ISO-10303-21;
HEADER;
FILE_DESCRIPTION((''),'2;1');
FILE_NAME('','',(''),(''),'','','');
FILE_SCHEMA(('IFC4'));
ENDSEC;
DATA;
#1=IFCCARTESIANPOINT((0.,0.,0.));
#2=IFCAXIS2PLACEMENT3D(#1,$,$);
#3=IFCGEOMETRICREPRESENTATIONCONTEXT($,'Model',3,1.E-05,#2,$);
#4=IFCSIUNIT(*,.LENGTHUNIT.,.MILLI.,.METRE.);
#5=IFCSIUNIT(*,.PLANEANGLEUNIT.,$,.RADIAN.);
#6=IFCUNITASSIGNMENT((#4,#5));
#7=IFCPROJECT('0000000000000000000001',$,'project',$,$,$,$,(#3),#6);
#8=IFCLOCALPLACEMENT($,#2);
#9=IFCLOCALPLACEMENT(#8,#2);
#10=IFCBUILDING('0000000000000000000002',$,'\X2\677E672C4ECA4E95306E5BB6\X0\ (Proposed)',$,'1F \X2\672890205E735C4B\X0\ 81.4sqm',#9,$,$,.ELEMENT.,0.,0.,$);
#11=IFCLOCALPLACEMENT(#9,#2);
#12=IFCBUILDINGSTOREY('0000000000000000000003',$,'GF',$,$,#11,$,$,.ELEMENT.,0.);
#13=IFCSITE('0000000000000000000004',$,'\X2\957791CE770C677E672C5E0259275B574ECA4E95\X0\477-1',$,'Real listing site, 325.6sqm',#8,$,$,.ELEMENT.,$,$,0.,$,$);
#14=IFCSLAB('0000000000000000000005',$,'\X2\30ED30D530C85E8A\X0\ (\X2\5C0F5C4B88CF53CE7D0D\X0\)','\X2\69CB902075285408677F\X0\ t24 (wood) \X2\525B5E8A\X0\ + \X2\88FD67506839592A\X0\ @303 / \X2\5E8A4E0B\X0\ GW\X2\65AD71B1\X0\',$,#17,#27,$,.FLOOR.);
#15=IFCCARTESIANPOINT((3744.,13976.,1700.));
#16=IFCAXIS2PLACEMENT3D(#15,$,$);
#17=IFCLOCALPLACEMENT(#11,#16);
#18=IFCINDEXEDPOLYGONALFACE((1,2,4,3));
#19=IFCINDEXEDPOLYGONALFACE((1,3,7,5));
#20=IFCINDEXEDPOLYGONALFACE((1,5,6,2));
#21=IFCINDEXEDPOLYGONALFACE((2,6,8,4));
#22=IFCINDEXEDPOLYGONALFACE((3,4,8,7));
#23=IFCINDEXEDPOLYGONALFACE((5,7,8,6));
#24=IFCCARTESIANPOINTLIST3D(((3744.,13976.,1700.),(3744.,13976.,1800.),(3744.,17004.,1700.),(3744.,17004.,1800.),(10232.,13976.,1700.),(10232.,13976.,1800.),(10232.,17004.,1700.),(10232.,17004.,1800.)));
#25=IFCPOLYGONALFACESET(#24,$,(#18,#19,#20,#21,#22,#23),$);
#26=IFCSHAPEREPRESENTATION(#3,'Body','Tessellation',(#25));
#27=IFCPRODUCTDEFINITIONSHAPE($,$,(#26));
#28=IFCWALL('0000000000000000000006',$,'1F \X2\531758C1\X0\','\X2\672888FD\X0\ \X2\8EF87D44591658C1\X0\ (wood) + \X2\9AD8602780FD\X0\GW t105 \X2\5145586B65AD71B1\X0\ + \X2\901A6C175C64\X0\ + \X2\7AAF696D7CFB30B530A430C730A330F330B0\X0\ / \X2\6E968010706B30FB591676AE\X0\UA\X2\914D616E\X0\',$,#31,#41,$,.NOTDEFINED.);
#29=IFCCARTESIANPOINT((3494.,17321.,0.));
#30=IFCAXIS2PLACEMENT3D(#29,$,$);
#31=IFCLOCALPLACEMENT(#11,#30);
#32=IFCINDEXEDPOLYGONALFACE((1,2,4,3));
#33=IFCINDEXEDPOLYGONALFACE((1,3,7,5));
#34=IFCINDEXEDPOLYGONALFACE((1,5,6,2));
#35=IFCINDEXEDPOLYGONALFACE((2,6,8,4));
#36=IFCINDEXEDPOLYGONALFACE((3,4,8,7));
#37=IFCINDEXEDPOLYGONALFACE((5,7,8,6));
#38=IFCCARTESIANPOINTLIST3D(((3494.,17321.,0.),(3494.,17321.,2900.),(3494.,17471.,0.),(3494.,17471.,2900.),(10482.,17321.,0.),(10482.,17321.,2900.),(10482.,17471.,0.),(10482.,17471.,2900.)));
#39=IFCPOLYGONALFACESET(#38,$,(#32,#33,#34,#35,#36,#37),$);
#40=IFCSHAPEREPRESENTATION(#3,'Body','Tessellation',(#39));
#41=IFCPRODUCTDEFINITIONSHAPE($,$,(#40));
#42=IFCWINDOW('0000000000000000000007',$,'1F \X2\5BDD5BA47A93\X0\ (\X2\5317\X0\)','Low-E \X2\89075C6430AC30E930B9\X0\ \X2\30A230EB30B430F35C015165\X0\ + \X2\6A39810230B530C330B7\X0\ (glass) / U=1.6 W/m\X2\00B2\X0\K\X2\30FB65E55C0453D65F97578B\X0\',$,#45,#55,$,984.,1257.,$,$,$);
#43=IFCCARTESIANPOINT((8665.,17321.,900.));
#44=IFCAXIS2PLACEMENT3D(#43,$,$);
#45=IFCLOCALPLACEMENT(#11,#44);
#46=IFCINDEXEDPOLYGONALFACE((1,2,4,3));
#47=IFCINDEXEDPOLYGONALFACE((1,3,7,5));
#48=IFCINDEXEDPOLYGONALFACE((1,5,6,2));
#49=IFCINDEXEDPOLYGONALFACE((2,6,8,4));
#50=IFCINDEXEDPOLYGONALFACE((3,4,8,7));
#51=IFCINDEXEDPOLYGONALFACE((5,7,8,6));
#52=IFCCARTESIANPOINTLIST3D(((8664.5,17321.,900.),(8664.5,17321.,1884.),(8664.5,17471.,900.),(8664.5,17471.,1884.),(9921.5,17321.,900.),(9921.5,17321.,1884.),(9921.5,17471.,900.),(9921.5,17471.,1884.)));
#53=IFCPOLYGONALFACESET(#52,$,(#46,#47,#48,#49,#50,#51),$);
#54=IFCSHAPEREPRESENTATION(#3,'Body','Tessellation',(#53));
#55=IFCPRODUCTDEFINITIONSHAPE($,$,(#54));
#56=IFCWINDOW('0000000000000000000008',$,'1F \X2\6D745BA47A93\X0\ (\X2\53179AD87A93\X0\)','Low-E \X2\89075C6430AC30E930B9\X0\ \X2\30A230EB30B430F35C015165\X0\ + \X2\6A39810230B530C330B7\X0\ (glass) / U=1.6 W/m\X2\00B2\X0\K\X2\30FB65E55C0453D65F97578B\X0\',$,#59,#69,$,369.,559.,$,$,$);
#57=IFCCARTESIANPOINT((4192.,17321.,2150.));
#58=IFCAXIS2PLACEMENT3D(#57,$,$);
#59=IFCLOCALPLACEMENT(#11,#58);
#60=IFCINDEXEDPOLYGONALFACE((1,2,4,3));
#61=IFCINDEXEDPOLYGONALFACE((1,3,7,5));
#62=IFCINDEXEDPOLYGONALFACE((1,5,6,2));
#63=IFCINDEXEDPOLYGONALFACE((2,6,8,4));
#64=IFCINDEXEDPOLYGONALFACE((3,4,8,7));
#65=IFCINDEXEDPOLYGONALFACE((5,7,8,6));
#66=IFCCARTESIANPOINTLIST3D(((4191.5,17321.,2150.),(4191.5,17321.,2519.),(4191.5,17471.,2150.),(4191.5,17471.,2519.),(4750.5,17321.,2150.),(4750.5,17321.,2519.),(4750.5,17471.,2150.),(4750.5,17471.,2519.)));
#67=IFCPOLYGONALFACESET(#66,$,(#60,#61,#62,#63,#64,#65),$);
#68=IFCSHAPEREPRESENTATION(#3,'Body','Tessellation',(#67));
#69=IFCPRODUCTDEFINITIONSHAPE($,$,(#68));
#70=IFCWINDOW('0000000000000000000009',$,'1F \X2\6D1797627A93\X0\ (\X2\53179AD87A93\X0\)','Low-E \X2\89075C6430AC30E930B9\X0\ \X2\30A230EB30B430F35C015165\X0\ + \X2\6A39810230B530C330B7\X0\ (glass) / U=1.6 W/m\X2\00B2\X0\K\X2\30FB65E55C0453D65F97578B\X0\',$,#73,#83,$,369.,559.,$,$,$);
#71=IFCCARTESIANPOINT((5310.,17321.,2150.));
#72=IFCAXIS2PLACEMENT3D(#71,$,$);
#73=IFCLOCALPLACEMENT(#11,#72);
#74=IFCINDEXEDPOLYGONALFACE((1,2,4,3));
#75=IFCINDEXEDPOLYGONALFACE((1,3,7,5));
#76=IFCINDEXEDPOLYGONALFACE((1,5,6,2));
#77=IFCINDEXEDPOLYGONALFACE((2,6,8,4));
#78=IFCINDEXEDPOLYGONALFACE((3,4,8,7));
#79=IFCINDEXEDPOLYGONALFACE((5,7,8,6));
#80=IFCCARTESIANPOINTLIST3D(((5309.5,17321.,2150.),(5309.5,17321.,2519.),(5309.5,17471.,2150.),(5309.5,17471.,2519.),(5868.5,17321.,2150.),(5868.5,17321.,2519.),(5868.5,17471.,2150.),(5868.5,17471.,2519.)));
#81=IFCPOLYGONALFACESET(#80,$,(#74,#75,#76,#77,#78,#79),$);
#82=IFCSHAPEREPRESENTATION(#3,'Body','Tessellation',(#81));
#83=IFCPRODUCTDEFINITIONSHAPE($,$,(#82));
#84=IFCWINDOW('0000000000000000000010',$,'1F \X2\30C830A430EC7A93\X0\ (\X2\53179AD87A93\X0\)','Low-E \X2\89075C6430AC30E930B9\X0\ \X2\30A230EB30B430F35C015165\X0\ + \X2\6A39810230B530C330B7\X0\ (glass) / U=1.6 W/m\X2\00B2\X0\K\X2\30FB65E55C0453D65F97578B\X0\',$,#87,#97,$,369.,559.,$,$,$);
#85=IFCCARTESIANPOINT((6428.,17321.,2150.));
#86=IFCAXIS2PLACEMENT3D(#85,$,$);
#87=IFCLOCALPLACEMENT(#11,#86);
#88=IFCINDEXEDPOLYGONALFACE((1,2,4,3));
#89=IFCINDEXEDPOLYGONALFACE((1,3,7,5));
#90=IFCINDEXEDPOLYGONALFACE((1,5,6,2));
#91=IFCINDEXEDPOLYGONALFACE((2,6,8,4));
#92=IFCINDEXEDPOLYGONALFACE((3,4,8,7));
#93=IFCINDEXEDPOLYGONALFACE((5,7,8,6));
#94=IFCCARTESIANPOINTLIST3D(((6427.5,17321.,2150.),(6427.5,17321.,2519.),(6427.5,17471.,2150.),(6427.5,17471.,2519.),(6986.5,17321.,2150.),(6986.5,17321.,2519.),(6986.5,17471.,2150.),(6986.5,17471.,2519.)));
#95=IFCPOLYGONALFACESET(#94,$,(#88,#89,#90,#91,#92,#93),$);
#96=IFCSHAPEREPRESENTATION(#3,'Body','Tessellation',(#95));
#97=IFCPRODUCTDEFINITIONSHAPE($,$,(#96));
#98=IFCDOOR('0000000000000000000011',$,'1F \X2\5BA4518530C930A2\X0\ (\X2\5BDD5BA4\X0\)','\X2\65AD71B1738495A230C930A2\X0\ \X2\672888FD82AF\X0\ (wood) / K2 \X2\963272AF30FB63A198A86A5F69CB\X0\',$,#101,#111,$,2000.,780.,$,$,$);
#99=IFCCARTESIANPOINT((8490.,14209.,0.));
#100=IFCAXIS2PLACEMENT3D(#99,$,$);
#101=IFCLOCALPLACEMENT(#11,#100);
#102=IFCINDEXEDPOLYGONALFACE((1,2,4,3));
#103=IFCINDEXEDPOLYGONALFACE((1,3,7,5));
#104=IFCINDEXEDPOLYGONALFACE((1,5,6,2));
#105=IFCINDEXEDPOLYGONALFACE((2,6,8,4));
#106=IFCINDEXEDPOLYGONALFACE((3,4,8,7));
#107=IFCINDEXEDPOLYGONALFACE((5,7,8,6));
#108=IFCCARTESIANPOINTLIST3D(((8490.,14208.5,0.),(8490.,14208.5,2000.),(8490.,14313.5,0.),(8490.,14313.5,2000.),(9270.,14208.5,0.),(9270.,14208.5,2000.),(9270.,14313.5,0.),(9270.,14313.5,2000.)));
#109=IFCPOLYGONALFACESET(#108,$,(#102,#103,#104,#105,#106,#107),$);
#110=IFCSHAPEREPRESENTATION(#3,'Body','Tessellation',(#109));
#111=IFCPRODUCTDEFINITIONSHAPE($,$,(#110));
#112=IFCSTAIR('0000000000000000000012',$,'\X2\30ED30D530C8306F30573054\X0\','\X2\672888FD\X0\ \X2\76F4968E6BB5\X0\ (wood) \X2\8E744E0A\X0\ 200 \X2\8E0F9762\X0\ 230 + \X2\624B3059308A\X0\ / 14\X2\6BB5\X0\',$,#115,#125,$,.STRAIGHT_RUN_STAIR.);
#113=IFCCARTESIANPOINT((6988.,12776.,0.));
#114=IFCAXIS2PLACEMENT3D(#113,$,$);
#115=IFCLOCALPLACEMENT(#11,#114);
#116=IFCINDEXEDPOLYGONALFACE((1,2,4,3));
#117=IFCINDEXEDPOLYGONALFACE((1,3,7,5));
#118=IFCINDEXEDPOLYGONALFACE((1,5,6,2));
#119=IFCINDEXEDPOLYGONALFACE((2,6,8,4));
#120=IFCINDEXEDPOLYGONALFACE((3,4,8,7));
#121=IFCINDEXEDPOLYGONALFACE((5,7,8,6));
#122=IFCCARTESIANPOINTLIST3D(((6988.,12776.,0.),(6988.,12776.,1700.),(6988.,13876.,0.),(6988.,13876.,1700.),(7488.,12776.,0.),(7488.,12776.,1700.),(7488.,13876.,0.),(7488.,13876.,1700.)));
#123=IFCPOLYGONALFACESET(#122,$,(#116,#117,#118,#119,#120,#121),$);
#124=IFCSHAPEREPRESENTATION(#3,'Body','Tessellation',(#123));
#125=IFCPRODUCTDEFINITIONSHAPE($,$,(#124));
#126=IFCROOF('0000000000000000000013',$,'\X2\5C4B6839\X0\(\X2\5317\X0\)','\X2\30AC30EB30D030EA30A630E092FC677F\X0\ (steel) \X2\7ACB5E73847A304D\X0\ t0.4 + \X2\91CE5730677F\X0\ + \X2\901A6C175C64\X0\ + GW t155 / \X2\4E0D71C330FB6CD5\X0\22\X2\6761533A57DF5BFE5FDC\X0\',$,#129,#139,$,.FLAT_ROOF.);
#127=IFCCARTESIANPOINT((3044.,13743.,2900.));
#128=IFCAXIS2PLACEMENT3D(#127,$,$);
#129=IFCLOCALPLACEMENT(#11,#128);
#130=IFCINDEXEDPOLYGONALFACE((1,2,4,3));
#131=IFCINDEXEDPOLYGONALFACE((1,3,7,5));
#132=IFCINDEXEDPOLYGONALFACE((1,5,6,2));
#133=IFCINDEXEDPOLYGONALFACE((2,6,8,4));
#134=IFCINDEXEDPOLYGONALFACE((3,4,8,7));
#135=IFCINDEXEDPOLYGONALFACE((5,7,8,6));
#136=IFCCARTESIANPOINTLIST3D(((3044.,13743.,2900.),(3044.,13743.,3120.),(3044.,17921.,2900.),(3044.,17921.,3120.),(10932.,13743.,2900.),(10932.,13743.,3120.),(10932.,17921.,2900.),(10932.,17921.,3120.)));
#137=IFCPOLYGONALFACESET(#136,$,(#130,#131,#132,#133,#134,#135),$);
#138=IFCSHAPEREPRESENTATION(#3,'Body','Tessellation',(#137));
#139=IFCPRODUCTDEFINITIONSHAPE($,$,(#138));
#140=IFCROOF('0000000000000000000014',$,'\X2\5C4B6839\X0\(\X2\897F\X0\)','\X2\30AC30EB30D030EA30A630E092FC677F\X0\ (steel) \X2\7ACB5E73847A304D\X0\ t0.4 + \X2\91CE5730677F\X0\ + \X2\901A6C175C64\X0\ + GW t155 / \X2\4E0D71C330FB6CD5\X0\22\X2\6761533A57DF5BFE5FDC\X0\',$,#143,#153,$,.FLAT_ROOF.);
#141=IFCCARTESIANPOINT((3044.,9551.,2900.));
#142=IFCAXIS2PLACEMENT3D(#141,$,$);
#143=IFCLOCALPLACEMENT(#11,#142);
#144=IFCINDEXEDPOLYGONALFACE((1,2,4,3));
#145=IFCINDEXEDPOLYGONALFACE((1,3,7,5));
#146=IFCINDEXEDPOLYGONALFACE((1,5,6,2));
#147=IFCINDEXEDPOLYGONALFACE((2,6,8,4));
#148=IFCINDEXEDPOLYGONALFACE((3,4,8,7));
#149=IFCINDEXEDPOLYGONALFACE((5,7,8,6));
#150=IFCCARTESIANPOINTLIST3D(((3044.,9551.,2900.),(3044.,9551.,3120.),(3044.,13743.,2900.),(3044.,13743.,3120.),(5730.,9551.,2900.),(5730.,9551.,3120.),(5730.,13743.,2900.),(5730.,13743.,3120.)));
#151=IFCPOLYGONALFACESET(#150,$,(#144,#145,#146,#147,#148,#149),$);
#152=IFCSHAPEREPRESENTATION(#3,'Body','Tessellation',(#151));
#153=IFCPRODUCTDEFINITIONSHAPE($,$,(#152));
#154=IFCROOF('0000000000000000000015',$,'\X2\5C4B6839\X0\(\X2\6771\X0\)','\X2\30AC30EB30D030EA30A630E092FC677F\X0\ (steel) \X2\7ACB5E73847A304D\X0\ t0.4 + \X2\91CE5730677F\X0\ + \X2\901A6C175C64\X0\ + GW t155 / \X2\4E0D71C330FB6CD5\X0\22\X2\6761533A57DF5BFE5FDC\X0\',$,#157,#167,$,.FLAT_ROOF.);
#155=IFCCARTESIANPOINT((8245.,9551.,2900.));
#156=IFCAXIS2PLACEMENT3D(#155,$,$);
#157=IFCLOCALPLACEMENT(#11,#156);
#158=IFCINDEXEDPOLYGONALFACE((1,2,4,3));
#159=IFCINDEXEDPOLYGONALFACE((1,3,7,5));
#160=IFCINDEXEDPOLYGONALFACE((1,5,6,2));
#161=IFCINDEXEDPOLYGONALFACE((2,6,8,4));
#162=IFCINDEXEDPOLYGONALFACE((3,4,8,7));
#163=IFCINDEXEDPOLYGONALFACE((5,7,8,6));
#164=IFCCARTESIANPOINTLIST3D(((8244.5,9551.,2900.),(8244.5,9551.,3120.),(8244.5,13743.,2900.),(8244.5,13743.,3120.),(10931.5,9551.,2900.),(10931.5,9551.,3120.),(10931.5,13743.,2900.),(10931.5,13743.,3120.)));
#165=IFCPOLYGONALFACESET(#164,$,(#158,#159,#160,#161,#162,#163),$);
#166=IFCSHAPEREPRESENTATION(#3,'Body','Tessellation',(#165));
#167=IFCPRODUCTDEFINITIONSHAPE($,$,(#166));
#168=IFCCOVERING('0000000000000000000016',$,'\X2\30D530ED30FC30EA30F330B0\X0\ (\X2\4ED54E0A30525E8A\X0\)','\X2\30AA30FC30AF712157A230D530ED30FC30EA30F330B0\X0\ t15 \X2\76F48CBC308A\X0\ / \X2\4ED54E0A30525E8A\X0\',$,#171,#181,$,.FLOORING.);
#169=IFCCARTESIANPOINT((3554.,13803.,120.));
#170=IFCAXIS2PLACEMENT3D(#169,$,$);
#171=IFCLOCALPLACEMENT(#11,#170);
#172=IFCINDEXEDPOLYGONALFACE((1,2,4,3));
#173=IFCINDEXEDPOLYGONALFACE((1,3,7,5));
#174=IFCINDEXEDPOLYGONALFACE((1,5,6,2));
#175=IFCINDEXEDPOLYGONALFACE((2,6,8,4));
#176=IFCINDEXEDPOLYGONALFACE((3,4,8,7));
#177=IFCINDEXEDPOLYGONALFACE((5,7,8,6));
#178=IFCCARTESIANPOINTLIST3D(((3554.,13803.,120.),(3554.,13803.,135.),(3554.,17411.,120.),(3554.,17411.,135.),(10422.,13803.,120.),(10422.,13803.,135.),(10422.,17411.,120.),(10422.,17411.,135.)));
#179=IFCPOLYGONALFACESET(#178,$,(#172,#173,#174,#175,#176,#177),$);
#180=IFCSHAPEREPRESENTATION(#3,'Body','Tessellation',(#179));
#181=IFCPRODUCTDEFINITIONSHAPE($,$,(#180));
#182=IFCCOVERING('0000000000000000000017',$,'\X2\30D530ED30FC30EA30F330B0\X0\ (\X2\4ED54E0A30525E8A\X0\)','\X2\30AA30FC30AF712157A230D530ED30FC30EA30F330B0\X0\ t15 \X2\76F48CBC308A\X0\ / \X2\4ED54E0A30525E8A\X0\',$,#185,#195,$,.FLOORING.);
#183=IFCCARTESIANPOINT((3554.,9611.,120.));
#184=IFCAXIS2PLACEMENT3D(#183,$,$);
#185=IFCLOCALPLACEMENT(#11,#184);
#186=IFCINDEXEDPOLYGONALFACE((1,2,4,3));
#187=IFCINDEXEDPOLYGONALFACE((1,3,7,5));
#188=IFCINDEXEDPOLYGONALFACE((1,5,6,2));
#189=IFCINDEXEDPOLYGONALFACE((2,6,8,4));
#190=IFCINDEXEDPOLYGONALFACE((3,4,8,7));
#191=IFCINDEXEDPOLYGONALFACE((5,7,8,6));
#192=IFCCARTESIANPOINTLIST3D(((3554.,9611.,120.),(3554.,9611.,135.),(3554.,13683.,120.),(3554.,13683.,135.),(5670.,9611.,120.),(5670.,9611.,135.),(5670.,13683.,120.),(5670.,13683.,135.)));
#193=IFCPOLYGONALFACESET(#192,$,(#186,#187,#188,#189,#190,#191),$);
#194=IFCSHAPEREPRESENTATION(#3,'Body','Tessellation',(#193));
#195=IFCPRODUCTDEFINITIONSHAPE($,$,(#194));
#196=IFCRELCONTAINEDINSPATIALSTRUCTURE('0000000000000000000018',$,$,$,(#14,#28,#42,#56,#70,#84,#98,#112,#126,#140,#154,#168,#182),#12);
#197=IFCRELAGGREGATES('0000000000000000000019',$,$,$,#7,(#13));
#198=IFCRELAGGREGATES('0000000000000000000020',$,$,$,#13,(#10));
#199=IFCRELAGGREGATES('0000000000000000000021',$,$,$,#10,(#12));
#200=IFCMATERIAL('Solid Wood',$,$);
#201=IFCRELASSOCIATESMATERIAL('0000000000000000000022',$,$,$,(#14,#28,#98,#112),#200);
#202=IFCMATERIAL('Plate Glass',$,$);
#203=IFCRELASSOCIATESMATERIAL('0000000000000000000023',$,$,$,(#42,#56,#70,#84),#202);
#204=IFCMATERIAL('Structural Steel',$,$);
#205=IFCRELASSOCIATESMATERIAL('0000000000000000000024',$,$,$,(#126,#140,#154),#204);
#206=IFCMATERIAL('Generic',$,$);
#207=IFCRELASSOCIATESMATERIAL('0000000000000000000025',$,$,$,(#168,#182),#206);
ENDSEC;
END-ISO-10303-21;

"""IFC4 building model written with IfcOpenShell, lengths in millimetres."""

from ifc_helpers import new_model, si_unit, frame, frame_2d, origin, place, context, project, spatial, rectangle, extrude, material, element, fill, save


model = new_model("IFC4")

# Units and contexts
model_context = context("Model", 3, precision=1e-05, world=origin())
ifc_project = project(units=[si_unit("LENGTHUNIT", "METRE", prefix="MILLI"), si_unit("PLANEANGLEUNIT", "RADIAN")], contexts=[model_context])

# Site, building, storey
site_placement = place(None, origin())
site = spatial("IfcSite", under=ifc_project, at=site_placement, Name="長野県松本市大字今井477-1", ObjectType="Real listing site, 325.6sqm", CompositionType="ELEMENT", RefElevation=0.0)
building_placement = place(site_placement, origin())
building = spatial("IfcBuilding", under=site, at=building_placement, Name="松本今井の家 (Proposed)", ObjectType="1F 木造平屋 81.4sqm", CompositionType="ELEMENT", ElevationOfRefHeight=0.0, ElevationOfTerrain=0.0)
storey_placement = place(building_placement, origin())
storey = spatial("IfcBuildingStorey", under=building, at=storey_placement, Name="GF", CompositionType="ELEMENT", Elevation=0.0)

# Slab
ifc_material_1 = material(Name="Solid Wood")
slab_1_placement = place(storey_placement, frame((3744.0, 13976.0, 1700.0)))
element("IfcSlab", 1, at=slab_1_placement, inside=storey, material=ifc_material_1, Name="ロフト床 (小屋裏収納)", Description="構造用合板 t24 (wood) 剛床 + 製材根太 @303 / 床下 GW断熱", PredefinedType="FLOOR", context=model_context, shape_type="SweptSolid", body=[
    extrude(rectangle(XDim=6488.0, YDim=3028.0, at=frame_2d((3244.0, 1514.0))), frame((3744.0, 13976.0, 1700.0)), (0.0, 0.0, 1.0), 100.0),
])

# Wall, openings, windows
wall_1_placement = place(storey_placement, frame((3494.0, 17321.0, 0.0)))
wall_1 = element("IfcWall", 2, at=wall_1_placement, inside=storey, material=ifc_material_1, Name="1F 北壁", Description="木製 軸組外壁 (wood) + 高性能GW t105 充填断熱 + 通気層 + 窯業系サイディング / 準耐火・外皮UA配慮", PredefinedType="NOTDEFINED", context=model_context, shape_type="SweptSolid", body=[
    extrude(rectangle(XDim=6988.0, YDim=150.0, at=frame_2d((3494.0, 75.0))), frame((3494.0, 17321.0, 0.0)), (0.0, 0.0, 1.0), 2900.0),
])
opening_1_placement = place(storey_placement, frame((8665.0, 17321.0, 900.0)))
opening_1 = element("IfcOpeningElement", 3, at=opening_1_placement, cuts=wall_1, PredefinedType="NOTDEFINED", context=model_context, shape_type="SweptSolid", body=[
    extrude(rectangle(XDim=1257.0, YDim=150.0, at=frame_2d((628.0, 75.0))), frame((8665.0, 17321.0, 900.0)), (0.0, 0.0, 1.0), 984.0),
])
opening_2_placement = place(storey_placement, frame((4192.0, 17321.0, 2150.0)))
opening_2 = element("IfcOpeningElement", 4, at=opening_2_placement, cuts=wall_1, PredefinedType="NOTDEFINED", context=model_context, shape_type="SweptSolid", body=[
    extrude(rectangle(XDim=559.0, YDim=150.0, at=frame_2d((279.0, 75.0))), frame((4192.0, 17321.0, 2150.0)), (0.0, 0.0, 1.0), 369.0),
])
opening_3_placement = place(storey_placement, frame((5310.0, 17321.0, 2150.0)))
opening_3 = element("IfcOpeningElement", 5, at=opening_3_placement, cuts=wall_1, PredefinedType="NOTDEFINED", context=model_context, shape_type="SweptSolid", body=[
    extrude(rectangle(XDim=559.0, YDim=150.0, at=frame_2d((279.0, 75.0))), frame((5310.0, 17321.0, 2150.0)), (0.0, 0.0, 1.0), 369.0),
])
opening_4_placement = place(storey_placement, frame((6428.0, 17321.0, 2150.0)))
opening_4 = element("IfcOpeningElement", 6, at=opening_4_placement, cuts=wall_1, PredefinedType="NOTDEFINED", context=model_context, shape_type="SweptSolid", body=[
    extrude(rectangle(XDim=559.0, YDim=150.0, at=frame_2d((279.0, 75.0))), frame((6428.0, 17321.0, 2150.0)), (0.0, 0.0, 1.0), 369.0),
])
ifc_material_2 = material(Name="Plate Glass")
window_1_placement = place(storey_placement, frame((8665.0, 17321.0, 900.0)))
window_1 = element("IfcWindow", 7, at=window_1_placement, inside=storey, material=ifc_material_2, Name="1F 寝室窓 (北)", Description="Low-E 複層ガラス アルゴン封入 + 樹脂サッシ (glass) / U=1.6 W/m²K・日射取得型", OverallHeight=984.0, OverallWidth=1257.0, context=model_context, shape_type="SweptSolid", body=[
    extrude(rectangle(XDim=1257.0, YDim=150.0, at=frame_2d((628.0, 75.0))), frame((8665.0, 17321.0, 900.0)), (0.0, 0.0, 1.0), 984.0),
])
fill(opening_1, window_1)
window_2_placement = place(storey_placement, frame((4192.0, 17321.0, 2150.0)))
window_2 = element("IfcWindow", 8, at=window_2_placement, inside=storey, material=ifc_material_2, Name="1F 浴室窓 (北高窓)", Description="Low-E 複層ガラス アルゴン封入 + 樹脂サッシ (glass) / U=1.6 W/m²K・日射取得型", OverallHeight=369.0, OverallWidth=559.0, context=model_context, shape_type="SweptSolid", body=[
    extrude(rectangle(XDim=559.0, YDim=150.0, at=frame_2d((279.0, 75.0))), frame((4192.0, 17321.0, 2150.0)), (0.0, 0.0, 1.0), 369.0),
])
fill(opening_2, window_2)
window_3_placement = place(storey_placement, frame((5310.0, 17321.0, 2150.0)))
window_3 = element("IfcWindow", 9, at=window_3_placement, inside=storey, material=ifc_material_2, Name="1F 洗面窓 (北高窓)", Description="Low-E 複層ガラス アルゴン封入 + 樹脂サッシ (glass) / U=1.6 W/m²K・日射取得型", OverallHeight=369.0, OverallWidth=559.0, context=model_context, shape_type="SweptSolid", body=[
    extrude(rectangle(XDim=559.0, YDim=150.0, at=frame_2d((279.0, 75.0))), frame((5310.0, 17321.0, 2150.0)), (0.0, 0.0, 1.0), 369.0),
])
fill(opening_3, window_3)
window_4_placement = place(storey_placement, frame((6428.0, 17321.0, 2150.0)))
window_4 = element("IfcWindow", 10, at=window_4_placement, inside=storey, material=ifc_material_2, Name="1F トイレ窓 (北高窓)", Description="Low-E 複層ガラス アルゴン封入 + 樹脂サッシ (glass) / U=1.6 W/m²K・日射取得型", OverallHeight=369.0, OverallWidth=559.0, context=model_context, shape_type="SweptSolid", body=[
    extrude(rectangle(XDim=559.0, YDim=150.0, at=frame_2d((279.0, 75.0))), frame((6428.0, 17321.0, 2150.0)), (0.0, 0.0, 1.0), 369.0),
])
fill(opening_4, window_4)

# Door
door_1_placement = place(storey_placement, frame((8490.0, 14209.0, 0.0)))
element("IfcDoor", 11, at=door_1_placement, inside=storey, material=ifc_material_1, Name="1F 室内ドア (寝室)", Description="断熱玄関ドア 木製芯 (wood) / K2 防犯・採風機構", OverallHeight=2000.0, OverallWidth=780.0, context=model_context, shape_type="SweptSolid", body=[
    extrude(rectangle(XDim=780.0, YDim=105.0, at=frame_2d((390.0, 52.0))), frame((8490.0, 14209.0, 0.0)), (0.0, 0.0, 1.0), 2000.0),
])

# Stair
stair_placement = place(storey_placement, frame((6988.0, 12776.0, 0.0)))
element("IfcStair", 12, at=stair_placement, inside=storey, material=ifc_material_1, Name="ロフトはしご", Description="木製 直階段 (wood) 蹴上 200 踏面 230 + 手すり / 14段", PredefinedType="STRAIGHT_RUN_STAIR", context=model_context, shape_type="SweptSolid", body=[
    extrude(rectangle(XDim=500.0, YDim=1100.0, at=frame_2d((250.0, 550.0))), frame((6988.0, 12776.0, 0.0)), (0.0, 0.0, 1.0), 1700.0),
])

# Roofs
ifc_material_3 = material(Name="Structural Steel")
roof_1_placement = place(storey_placement, frame((3044.0, 13743.0, 2900.0)))
element("IfcRoof", 13, at=roof_1_placement, inside=storey, material=ifc_material_3, Name="屋根(北)", Description="ガルバリウム鋼板 (steel) 立平葺き t0.4 + 野地板 + 通気層 + GW t155 / 不燃・法22条区域対応", PredefinedType="FLAT_ROOF", context=model_context, shape_type="SweptSolid", body=[
    extrude(rectangle(XDim=7888.0, YDim=4178.0, at=frame_2d((3944.0, 2089.0))), frame((3044.0, 13743.0, 2900.0)), (0.0, 0.0, 1.0), 220.0),
])
roof_2_placement = place(storey_placement, frame((3044.0, 9551.0, 2900.0)))
element("IfcRoof", 14, at=roof_2_placement, inside=storey, material=ifc_material_3, Name="屋根(西)", Description="ガルバリウム鋼板 (steel) 立平葺き t0.4 + 野地板 + 通気層 + GW t155 / 不燃・法22条区域対応", PredefinedType="FLAT_ROOF", context=model_context, shape_type="SweptSolid", body=[
    extrude(rectangle(XDim=2686.0, YDim=4192.0, at=frame_2d((1343.0, 2096.0))), frame((3044.0, 9551.0, 2900.0)), (0.0, 0.0, 1.0), 220.0),
])
roof_3_placement = place(storey_placement, frame((8245.0, 9551.0, 2900.0)))
element("IfcRoof", 15, at=roof_3_placement, inside=storey, material=ifc_material_3, Name="屋根(東)", Description="ガルバリウム鋼板 (steel) 立平葺き t0.4 + 野地板 + 通気層 + GW t155 / 不燃・法22条区域対応", PredefinedType="FLAT_ROOF", context=model_context, shape_type="SweptSolid", body=[
    extrude(rectangle(XDim=2687.0, YDim=4192.0, at=frame_2d((1343.0, 2096.0))), frame((8245.0, 9551.0, 2900.0)), (0.0, 0.0, 1.0), 220.0),
])

# Coverings
ifc_material_4 = material(Name="Generic")
covering_1_placement = place(storey_placement, frame((3554.0, 13803.0, 120.0)))
element("IfcCovering", 16, at=covering_1_placement, inside=storey, material=ifc_material_4, Name="フローリング (仕上げ床)", Description="オーク無垢フローリング t15 直貼り / 仕上げ床", PredefinedType="FLOORING", context=model_context, shape_type="SweptSolid", body=[
    extrude(rectangle(XDim=6868.0, YDim=3608.0, at=frame_2d((3434.0, 1804.0))), frame((3554.0, 13803.0, 120.0)), (0.0, 0.0, 1.0), 15.0),
])
covering_2_placement = place(storey_placement, frame((3554.0, 9611.0, 120.0)))
element("IfcCovering", 17, at=covering_2_placement, inside=storey, material=ifc_material_4, Name="フローリング (仕上げ床)", Description="オーク無垢フローリング t15 直貼り / 仕上げ床", PredefinedType="FLOORING", context=model_context, shape_type="SweptSolid", body=[
    extrude(rectangle(XDim=2116.0, YDim=4072.0, at=frame_2d((1058.0, 2036.0))), frame((3554.0, 9611.0, 120.0)), (0.0, 0.0, 1.0), 15.0),
])

save(model, "model.ifc")
